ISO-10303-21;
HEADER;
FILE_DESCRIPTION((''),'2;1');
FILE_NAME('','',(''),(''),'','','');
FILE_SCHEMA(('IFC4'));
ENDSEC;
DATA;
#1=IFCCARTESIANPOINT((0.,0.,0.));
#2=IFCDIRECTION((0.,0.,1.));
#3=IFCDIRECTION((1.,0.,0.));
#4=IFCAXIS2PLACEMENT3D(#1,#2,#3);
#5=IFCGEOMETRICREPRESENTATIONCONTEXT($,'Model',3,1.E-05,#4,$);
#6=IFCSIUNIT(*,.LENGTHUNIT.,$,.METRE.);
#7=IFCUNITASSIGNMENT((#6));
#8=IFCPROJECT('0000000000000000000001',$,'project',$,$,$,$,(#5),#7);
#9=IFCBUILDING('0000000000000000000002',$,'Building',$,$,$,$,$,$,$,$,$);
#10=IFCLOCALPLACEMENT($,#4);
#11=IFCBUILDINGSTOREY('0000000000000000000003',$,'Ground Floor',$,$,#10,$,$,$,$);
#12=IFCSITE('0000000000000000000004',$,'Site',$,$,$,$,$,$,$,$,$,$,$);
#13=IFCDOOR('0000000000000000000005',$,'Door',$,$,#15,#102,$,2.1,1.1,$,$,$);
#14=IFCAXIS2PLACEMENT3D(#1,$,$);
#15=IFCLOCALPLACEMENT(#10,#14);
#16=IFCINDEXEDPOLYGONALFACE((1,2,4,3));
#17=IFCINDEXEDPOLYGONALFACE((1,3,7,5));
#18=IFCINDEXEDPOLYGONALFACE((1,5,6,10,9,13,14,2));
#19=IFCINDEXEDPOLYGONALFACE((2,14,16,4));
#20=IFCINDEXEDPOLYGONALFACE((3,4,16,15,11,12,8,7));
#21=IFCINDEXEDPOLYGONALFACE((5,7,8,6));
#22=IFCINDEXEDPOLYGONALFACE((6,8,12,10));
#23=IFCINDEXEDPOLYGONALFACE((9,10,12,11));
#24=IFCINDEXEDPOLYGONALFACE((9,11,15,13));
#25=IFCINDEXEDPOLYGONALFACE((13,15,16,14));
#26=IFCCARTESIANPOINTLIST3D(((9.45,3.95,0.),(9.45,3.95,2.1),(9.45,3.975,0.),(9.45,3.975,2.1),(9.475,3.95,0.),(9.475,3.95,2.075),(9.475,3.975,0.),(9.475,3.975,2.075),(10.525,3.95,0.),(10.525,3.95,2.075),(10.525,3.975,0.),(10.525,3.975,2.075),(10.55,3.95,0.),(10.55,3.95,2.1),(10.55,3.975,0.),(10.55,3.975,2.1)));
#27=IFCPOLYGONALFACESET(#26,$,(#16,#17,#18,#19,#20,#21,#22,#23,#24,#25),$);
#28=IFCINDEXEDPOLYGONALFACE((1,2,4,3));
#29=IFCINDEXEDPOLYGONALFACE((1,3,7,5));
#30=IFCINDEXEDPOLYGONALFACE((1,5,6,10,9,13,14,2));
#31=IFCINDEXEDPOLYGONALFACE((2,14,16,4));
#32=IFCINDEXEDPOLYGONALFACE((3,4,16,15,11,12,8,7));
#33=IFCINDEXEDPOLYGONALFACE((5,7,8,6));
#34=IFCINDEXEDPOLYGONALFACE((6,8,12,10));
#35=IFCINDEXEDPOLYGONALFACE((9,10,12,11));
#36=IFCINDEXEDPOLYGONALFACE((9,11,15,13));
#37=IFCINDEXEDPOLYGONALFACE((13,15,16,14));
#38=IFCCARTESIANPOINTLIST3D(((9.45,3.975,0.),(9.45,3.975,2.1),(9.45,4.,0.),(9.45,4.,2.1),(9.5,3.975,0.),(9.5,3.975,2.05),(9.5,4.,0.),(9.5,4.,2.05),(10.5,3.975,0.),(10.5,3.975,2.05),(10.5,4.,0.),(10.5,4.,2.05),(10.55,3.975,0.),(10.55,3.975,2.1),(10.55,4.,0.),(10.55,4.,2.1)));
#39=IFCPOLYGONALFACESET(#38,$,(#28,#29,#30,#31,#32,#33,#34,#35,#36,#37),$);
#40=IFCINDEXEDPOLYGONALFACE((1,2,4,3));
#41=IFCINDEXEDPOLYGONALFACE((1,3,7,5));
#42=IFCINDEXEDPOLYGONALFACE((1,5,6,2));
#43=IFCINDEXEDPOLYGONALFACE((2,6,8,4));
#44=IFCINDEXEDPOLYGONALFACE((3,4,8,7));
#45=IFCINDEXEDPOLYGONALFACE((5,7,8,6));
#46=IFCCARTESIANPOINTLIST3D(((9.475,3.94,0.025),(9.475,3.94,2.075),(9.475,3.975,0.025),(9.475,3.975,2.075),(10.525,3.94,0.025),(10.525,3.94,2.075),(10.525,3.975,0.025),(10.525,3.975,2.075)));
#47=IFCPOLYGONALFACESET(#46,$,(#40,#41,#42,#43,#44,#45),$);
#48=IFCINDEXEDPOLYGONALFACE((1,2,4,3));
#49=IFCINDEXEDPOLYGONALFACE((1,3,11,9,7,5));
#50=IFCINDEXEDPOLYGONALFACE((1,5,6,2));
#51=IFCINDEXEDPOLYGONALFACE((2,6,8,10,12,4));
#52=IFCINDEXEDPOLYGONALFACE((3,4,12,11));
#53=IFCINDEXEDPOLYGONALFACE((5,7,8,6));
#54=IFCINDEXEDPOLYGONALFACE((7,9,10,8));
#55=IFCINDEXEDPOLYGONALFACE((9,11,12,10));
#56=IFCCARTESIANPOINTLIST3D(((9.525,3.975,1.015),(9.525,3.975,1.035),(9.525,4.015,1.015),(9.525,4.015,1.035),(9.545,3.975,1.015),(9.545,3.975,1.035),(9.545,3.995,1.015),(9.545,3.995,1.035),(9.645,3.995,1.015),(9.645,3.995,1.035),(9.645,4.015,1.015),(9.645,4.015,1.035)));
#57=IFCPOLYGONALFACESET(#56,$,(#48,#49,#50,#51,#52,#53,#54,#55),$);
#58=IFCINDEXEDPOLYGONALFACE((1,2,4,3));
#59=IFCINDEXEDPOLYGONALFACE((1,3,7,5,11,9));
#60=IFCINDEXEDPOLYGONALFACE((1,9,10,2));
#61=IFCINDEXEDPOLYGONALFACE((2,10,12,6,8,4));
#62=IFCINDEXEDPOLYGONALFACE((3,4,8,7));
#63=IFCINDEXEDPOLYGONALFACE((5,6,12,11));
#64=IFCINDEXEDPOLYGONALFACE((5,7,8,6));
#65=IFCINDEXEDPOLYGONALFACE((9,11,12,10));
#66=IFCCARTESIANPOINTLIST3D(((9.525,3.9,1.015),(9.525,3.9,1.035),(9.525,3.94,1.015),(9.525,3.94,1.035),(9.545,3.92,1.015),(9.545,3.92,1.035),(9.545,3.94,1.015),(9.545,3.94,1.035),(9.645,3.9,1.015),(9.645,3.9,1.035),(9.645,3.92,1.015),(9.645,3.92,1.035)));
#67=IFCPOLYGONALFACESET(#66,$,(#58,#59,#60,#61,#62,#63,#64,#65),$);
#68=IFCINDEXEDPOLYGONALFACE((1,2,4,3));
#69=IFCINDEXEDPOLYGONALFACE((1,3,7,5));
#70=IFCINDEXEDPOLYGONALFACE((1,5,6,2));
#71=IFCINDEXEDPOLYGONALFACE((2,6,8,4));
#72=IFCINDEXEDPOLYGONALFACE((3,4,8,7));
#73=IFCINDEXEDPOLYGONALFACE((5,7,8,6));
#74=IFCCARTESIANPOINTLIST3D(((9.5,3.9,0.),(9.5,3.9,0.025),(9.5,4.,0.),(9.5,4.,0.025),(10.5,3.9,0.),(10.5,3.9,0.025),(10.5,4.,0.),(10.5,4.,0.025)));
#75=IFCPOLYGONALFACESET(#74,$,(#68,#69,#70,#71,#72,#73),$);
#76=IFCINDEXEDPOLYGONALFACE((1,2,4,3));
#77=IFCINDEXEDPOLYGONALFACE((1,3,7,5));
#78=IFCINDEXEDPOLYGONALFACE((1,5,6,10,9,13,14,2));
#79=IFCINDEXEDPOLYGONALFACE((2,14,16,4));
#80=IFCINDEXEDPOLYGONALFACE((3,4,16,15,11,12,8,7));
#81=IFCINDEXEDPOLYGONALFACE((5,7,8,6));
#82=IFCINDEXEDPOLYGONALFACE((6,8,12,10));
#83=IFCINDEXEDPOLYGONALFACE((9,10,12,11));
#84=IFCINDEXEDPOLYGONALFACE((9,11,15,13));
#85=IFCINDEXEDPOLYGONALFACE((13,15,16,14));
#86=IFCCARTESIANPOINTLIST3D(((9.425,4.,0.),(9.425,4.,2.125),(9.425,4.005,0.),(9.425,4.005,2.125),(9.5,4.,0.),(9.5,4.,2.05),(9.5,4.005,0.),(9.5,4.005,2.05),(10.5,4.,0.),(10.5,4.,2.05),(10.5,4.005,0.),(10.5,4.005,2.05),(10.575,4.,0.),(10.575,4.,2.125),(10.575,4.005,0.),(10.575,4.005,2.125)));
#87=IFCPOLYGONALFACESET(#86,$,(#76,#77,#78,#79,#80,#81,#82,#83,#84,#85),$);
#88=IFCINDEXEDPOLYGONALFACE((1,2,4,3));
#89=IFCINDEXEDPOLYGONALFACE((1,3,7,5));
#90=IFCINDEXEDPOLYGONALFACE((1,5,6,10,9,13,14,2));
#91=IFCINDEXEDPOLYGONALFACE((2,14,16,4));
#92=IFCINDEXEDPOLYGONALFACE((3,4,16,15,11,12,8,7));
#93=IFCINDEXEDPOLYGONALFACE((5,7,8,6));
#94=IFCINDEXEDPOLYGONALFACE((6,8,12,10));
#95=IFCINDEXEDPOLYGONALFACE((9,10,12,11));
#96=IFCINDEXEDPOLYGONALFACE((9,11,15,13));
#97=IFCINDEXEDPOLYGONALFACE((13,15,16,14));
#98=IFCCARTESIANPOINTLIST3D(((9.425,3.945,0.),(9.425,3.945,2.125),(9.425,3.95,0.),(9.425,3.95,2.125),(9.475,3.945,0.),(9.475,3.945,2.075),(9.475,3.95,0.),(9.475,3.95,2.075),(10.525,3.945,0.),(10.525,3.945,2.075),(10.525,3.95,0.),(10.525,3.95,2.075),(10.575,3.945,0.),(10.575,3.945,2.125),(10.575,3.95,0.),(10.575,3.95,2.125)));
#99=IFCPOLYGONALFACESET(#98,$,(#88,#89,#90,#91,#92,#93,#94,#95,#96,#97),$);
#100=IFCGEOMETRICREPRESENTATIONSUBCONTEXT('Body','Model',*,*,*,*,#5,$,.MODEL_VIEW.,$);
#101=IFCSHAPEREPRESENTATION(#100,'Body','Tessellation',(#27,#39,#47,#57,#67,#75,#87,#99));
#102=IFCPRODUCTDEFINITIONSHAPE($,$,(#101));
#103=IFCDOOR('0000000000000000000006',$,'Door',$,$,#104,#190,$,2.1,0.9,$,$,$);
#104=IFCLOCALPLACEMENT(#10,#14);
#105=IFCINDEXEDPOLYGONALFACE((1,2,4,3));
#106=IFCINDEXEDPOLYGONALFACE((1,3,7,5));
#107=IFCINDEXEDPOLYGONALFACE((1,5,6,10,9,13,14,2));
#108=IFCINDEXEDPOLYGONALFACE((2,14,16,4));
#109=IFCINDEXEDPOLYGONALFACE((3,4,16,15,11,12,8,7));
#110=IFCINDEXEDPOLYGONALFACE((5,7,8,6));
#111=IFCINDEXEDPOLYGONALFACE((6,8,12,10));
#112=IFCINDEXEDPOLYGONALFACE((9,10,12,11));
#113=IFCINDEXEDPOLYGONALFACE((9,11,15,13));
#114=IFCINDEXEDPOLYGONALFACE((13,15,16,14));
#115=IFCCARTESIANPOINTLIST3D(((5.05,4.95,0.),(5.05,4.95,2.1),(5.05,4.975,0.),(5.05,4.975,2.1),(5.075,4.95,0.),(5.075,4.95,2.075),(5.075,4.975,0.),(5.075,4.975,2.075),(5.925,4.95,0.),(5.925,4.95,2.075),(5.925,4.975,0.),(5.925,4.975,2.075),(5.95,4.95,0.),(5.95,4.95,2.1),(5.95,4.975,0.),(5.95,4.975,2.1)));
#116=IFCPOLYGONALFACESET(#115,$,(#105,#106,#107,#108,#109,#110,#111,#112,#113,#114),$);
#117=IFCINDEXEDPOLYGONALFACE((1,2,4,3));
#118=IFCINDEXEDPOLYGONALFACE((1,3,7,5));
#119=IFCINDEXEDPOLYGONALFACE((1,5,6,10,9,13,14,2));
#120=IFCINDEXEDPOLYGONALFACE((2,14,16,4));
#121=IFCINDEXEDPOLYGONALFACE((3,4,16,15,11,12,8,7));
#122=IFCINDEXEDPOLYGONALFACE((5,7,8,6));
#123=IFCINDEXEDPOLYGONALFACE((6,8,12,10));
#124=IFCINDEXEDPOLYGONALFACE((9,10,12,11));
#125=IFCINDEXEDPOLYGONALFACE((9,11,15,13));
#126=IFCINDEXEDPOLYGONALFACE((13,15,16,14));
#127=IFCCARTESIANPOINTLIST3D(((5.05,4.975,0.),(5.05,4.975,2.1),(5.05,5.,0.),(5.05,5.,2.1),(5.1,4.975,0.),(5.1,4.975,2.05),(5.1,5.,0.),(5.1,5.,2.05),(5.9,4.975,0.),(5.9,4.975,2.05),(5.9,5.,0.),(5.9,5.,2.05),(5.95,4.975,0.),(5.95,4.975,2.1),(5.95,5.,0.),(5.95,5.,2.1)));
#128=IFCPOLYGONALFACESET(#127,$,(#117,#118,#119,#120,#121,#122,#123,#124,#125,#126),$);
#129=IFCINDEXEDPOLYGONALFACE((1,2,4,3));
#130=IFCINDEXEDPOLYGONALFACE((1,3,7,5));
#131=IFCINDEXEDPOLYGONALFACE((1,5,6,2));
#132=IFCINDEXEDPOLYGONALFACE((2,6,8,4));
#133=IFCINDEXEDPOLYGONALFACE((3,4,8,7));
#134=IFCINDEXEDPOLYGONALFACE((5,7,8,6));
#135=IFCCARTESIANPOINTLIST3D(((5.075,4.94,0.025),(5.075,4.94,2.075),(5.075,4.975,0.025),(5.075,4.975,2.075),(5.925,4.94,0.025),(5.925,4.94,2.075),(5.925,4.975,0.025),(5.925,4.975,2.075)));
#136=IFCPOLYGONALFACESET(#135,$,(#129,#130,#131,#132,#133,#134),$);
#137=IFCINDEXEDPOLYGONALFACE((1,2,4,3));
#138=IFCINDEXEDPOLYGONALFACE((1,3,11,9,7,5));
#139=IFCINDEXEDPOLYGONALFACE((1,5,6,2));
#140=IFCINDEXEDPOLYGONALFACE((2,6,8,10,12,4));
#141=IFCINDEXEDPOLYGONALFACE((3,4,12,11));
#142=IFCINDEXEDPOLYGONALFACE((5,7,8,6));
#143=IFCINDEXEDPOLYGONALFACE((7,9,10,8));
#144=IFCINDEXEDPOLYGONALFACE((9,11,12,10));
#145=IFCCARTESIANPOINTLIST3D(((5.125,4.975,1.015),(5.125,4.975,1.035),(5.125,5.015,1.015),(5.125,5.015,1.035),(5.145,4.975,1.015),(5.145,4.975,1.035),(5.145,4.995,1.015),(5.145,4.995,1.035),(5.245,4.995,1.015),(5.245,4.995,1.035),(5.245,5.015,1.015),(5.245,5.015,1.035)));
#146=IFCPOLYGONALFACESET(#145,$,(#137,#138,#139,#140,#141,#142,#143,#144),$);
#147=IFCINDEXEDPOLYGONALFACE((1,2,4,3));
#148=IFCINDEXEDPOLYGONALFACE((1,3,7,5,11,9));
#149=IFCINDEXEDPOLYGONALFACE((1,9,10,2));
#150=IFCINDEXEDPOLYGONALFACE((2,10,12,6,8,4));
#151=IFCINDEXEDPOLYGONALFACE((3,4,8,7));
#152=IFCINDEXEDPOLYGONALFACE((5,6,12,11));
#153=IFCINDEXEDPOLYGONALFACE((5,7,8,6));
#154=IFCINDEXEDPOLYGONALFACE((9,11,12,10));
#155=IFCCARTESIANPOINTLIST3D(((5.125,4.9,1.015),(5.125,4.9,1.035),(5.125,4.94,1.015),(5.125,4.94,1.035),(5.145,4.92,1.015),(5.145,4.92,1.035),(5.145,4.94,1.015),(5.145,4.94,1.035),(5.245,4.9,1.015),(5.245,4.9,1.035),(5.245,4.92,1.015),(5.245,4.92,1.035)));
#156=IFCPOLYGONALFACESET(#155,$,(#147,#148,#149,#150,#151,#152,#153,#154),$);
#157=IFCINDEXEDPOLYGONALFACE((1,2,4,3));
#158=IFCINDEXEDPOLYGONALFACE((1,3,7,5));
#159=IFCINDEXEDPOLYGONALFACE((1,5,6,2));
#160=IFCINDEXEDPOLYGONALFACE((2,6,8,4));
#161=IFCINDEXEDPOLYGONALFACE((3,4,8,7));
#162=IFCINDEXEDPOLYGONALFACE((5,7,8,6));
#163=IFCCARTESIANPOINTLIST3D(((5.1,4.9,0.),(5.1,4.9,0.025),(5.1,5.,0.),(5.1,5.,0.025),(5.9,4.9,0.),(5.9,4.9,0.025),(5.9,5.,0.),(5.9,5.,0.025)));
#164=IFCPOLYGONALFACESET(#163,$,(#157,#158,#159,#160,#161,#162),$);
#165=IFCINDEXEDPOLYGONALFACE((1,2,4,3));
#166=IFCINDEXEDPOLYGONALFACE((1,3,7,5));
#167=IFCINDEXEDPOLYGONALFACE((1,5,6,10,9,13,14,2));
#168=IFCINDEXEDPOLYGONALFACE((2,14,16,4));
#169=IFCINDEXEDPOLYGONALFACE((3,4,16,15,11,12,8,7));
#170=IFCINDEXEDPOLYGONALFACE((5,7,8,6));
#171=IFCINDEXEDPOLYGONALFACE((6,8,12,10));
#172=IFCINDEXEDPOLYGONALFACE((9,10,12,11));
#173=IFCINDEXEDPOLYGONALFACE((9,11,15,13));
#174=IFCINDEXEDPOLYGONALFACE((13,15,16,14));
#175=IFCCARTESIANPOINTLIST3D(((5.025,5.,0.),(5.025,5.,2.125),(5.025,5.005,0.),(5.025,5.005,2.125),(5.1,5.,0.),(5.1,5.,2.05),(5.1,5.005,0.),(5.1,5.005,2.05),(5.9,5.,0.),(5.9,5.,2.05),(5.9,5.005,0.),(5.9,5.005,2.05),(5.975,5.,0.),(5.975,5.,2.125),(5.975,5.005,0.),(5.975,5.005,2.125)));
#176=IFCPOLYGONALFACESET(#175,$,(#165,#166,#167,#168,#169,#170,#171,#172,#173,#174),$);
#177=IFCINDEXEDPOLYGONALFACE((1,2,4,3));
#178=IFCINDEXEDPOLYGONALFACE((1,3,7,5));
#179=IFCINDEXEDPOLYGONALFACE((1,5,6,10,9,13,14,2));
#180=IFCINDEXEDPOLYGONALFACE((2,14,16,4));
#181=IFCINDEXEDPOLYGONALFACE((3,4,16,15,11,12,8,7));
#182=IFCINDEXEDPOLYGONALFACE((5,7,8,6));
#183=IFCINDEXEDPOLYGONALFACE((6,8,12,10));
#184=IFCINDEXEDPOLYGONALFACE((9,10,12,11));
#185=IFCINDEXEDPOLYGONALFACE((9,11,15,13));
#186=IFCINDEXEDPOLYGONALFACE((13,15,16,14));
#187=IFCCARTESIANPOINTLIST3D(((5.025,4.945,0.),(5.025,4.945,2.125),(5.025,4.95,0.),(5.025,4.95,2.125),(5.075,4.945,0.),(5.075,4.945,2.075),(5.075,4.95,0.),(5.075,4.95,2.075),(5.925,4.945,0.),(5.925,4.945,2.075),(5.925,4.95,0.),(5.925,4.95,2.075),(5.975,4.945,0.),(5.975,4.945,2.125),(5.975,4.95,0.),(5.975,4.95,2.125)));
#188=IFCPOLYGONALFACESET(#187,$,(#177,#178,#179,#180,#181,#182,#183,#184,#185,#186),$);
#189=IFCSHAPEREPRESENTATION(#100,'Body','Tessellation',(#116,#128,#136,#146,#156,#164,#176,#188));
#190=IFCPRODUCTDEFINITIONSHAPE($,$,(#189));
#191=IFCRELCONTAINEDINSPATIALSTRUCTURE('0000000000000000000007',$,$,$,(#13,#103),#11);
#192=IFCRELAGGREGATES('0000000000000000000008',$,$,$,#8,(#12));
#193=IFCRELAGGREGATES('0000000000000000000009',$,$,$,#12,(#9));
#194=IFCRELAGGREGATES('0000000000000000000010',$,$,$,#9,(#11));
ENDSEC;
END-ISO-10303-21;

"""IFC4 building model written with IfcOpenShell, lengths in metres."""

from ifc_helpers import new_model, si_unit, frame, origin_with_axes, place, context, subcontext, project, spatial, line, indexed_curve, outline, extrude, element, save


model = new_model("IFC4")

# Units and contexts
model_context = context("Model", 3, precision=1e-05, world=origin_with_axes())
body_context = subcontext(model_context, "Body", "Model", "MODEL_VIEW")
ifc_project = project(units=[si_unit("LENGTHUNIT", "METRE")], contexts=[model_context])

# Site, building, storey
site = spatial("IfcSite", under=ifc_project, Name="Site")
building = spatial("IfcBuilding", under=site, Name="Building")
storey_placement = place(None, origin_with_axes())
storey = spatial("IfcBuildingStorey", under=building, at=storey_placement, Name="Ground Floor")

# Doors
door_1_placement = place(storey_placement, frame((10.55, 4.0, 0.0), z_axis=(0.0, 0.0, 1.0), x_axis=(-1.0, 0.0, 0.0)))
element("IfcDoor", 1, at=door_1_placement, inside=storey, Name="Door", OverallHeight=2.1, OverallWidth=1.1, context=body_context, shape_type="SweptSolid", body=[
    extrude(outline(indexed_curve([(0.0, 0.0), (0.0, 2.1), (1.1, 2.1), (1.1, 0.0), (1.075, 0.0), (1.075, 2.075), (0.025, 2.075), (0.025, 0.0)], segments=[line(1, 2, 3, 4, 5, 6, 7, 8, 1)])), frame((0.0, 0.025, 0.0), z_axis=(0.0, -1.0, 0.0), x_axis=(1.0, 0.0, 0.0)), (0.0, 0.0, -1.0), 0.025),
    extrude(outline(indexed_curve([(0.0, 0.0), (0.0, 2.1), (1.1, 2.1), (1.1, 0.0), (1.05, 0.0), (1.05, 2.05), (0.05, 2.05), (0.05, 0.0)], segments=[line(1, 2, 3, 4, 5, 6, 7, 8, 1)])), frame((0.0, 0.0, 0.0), z_axis=(0.0, -1.0, 0.0), x_axis=(1.0, 0.0, 0.0)), (0.0, 0.0, -1.0), 0.025),
    extrude(outline(indexed_curve([(0.0, 0.0), (1.05, 0.0), (1.05, 0.035), (0.0, 0.035)], segments=[line(1, 2, 3, 4, 1)])), frame((0.025, 0.025, 0.025), z_axis=(0.0, 0.0, 1.0), x_axis=(1.0, 0.0, 0.0)), (0.0, 0.0, 1.0), 2.05),
    extrude(outline(indexed_curve([(0.0, 0.0), (0.0, -0.04), (-0.12, -0.04), (-0.12, -0.02), (-0.02, -0.02), (-0.02, 0.0)], segments=[line(1, 2, 3, 4, 5, 6, 1)])), frame((1.025, 0.025, 1.015), z_axis=(0.0, 0.0, 1.0), x_axis=(1.0, 0.0, 0.0)), (0.0, 0.0, 1.0), 0.02),
    extrude(outline(indexed_curve([(0.0, 0.0), (0.0, 0.04), (-0.12, 0.04), (-0.12, 0.02), (-0.02, 0.02), (-0.02, 0.0)], segments=[line(1, 2, 3, 4, 5, 6, 1)])), frame((1.025, 0.06, 1.015), z_axis=(0.0, 0.0, 1.0), x_axis=(1.0, 0.0, 0.0)), (0.0, 0.0, 1.0), 0.02),
    extrude(outline(indexed_curve([(0.0, 0.0), (1.0, 0.0), (1.0, 0.1), (0.0, 0.1)], segments=[line(1, 2, 3, 4, 1)])), frame((0.05, 0.0, 0.0), z_axis=(0.0, 0.0, 1.0), x_axis=(1.0, 0.0, 0.0)), (0.0, 0.0, 1.0), 0.025),
    extrude(outline(indexed_curve([(0.0, 0.0), (0.0, 2.125), (1.15, 2.125), (1.15, 0.0), (1.075, 0.0), (1.075, 2.05), (0.075, 2.05), (0.075, 0.0)], segments=[line(1, 2, 3, 4, 5, 6, 7, 8, 1)])), frame((-0.025, -0.005, 0.0), z_axis=(0.0, -1.0, 0.0), x_axis=(1.0, 0.0, 0.0)), (0.0, 0.0, -1.0), 0.005),
    extrude(outline(indexed_curve([(0.0, 0.0), (0.0, 2.125), (1.15, 2.125), (1.15, 0.0), (1.1, 0.0), (1.1, 2.075), (0.05, 2.075), (0.05, 0.0)], segments=[line(1, 2, 3, 4, 5, 6, 7, 8, 1)])), frame((-0.025, 0.05, 0.0), z_axis=(0.0, -1.0, 0.0), x_axis=(1.0, 0.0, 0.0)), (0.0, 0.0, -1.0), 0.005),
])
door_2_placement = place(storey_placement, frame((5.95, 5.0, 0.0), z_axis=(0.0, 0.0, 1.0), x_axis=(-1.0, 0.0, 0.0)))
element("IfcDoor", 2, at=door_2_placement, inside=storey, Name="Door", OverallHeight=2.1, OverallWidth=0.9, context=body_context, shape_type="SweptSolid", body=[
    extrude(outline(indexed_curve([(0.0, 0.0), (0.0, 2.1), (0.9, 2.1), (0.9, 0.0), (0.875, 0.0), (0.875, 2.075), (0.025, 2.075), (0.025, 0.0)], segments=[line(1, 2, 3, 4, 5, 6, 7, 8, 1)])), frame((0.0, 0.025, 0.0), z_axis=(0.0, -1.0, 0.0), x_axis=(1.0, 0.0, 0.0)), (0.0, 0.0, -1.0), 0.025),
    extrude(outline(indexed_curve([(0.0, 0.0), (0.0, 2.1), (0.9, 2.1), (0.9, 0.0), (0.85, 0.0), (0.85, 2.05), (0.05, 2.05), (0.05, 0.0)], segments=[line(1, 2, 3, 4, 5, 6, 7, 8, 1)])), frame((0.0, 0.0, 0.0), z_axis=(0.0, -1.0, 0.0), x_axis=(1.0, 0.0, 0.0)), (0.0, 0.0, -1.0), 0.025),
    extrude(outline(indexed_curve([(0.0, 0.0), (0.85, 0.0), (0.85, 0.035), (0.0, 0.035)], segments=[line(1, 2, 3, 4, 1)])), frame((0.025, 0.025, 0.025), z_axis=(0.0, 0.0, 1.0), x_axis=(1.0, 0.0, 0.0)), (0.0, 0.0, 1.0), 2.05),
    extrude(outline(indexed_curve([(0.0, 0.0), (0.0, -0.04), (-0.12, -0.04), (-0.12, -0.02), (-0.02, -0.02), (-0.02, 0.0)], segments=[line(1, 2, 3, 4, 5, 6, 1)])), frame((0.825, 0.025, 1.015), z_axis=(0.0, 0.0, 1.0), x_axis=(1.0, 0.0, 0.0)), (0.0, 0.0, 1.0), 0.02),
    extrude(outline(indexed_curve([(0.0, 0.0), (0.0, 0.04), (-0.12, 0.04), (-0.12, 0.02), (-0.02, 0.02), (-0.02, 0.0)], segments=[line(1, 2, 3, 4, 5, 6, 1)])), frame((0.825, 0.06, 1.015), z_axis=(0.0, 0.0, 1.0), x_axis=(1.0, 0.0, 0.0)), (0.0, 0.0, 1.0), 0.02),
    extrude(outline(indexed_curve([(0.0, 0.0), (0.8, 0.0), (0.8, 0.1), (0.0, 0.1)], segments=[line(1, 2, 3, 4, 1)])), frame((0.05, 0.0, 0.0), z_axis=(0.0, 0.0, 1.0), x_axis=(1.0, 0.0, 0.0)), (0.0, 0.0, 1.0), 0.025),
    extrude(outline(indexed_curve([(0.0, 0.0), (0.0, 2.125), (0.95, 2.125), (0.95, 0.0), (0.875, 0.0), (0.875, 2.05), (0.075, 2.05), (0.075, 0.0)], segments=[line(1, 2, 3, 4, 5, 6, 7, 8, 1)])), frame((-0.025, -0.005, 0.0), z_axis=(0.0, -1.0, 0.0), x_axis=(1.0, 0.0, 0.0)), (0.0, 0.0, -1.0), 0.005),
    extrude(outline(indexed_curve([(0.0, 0.0), (0.0, 2.125), (0.95, 2.125), (0.95, 0.0), (0.9, 0.0), (0.9, 2.075), (0.05, 2.075), (0.05, 0.0)], segments=[line(1, 2, 3, 4, 5, 6, 7, 8, 1)])), frame((-0.025, 0.05, 0.0), z_axis=(0.0, -1.0, 0.0), x_axis=(1.0, 0.0, 0.0)), (0.0, 0.0, -1.0), 0.005),
])

save(model, "model.ifc")
